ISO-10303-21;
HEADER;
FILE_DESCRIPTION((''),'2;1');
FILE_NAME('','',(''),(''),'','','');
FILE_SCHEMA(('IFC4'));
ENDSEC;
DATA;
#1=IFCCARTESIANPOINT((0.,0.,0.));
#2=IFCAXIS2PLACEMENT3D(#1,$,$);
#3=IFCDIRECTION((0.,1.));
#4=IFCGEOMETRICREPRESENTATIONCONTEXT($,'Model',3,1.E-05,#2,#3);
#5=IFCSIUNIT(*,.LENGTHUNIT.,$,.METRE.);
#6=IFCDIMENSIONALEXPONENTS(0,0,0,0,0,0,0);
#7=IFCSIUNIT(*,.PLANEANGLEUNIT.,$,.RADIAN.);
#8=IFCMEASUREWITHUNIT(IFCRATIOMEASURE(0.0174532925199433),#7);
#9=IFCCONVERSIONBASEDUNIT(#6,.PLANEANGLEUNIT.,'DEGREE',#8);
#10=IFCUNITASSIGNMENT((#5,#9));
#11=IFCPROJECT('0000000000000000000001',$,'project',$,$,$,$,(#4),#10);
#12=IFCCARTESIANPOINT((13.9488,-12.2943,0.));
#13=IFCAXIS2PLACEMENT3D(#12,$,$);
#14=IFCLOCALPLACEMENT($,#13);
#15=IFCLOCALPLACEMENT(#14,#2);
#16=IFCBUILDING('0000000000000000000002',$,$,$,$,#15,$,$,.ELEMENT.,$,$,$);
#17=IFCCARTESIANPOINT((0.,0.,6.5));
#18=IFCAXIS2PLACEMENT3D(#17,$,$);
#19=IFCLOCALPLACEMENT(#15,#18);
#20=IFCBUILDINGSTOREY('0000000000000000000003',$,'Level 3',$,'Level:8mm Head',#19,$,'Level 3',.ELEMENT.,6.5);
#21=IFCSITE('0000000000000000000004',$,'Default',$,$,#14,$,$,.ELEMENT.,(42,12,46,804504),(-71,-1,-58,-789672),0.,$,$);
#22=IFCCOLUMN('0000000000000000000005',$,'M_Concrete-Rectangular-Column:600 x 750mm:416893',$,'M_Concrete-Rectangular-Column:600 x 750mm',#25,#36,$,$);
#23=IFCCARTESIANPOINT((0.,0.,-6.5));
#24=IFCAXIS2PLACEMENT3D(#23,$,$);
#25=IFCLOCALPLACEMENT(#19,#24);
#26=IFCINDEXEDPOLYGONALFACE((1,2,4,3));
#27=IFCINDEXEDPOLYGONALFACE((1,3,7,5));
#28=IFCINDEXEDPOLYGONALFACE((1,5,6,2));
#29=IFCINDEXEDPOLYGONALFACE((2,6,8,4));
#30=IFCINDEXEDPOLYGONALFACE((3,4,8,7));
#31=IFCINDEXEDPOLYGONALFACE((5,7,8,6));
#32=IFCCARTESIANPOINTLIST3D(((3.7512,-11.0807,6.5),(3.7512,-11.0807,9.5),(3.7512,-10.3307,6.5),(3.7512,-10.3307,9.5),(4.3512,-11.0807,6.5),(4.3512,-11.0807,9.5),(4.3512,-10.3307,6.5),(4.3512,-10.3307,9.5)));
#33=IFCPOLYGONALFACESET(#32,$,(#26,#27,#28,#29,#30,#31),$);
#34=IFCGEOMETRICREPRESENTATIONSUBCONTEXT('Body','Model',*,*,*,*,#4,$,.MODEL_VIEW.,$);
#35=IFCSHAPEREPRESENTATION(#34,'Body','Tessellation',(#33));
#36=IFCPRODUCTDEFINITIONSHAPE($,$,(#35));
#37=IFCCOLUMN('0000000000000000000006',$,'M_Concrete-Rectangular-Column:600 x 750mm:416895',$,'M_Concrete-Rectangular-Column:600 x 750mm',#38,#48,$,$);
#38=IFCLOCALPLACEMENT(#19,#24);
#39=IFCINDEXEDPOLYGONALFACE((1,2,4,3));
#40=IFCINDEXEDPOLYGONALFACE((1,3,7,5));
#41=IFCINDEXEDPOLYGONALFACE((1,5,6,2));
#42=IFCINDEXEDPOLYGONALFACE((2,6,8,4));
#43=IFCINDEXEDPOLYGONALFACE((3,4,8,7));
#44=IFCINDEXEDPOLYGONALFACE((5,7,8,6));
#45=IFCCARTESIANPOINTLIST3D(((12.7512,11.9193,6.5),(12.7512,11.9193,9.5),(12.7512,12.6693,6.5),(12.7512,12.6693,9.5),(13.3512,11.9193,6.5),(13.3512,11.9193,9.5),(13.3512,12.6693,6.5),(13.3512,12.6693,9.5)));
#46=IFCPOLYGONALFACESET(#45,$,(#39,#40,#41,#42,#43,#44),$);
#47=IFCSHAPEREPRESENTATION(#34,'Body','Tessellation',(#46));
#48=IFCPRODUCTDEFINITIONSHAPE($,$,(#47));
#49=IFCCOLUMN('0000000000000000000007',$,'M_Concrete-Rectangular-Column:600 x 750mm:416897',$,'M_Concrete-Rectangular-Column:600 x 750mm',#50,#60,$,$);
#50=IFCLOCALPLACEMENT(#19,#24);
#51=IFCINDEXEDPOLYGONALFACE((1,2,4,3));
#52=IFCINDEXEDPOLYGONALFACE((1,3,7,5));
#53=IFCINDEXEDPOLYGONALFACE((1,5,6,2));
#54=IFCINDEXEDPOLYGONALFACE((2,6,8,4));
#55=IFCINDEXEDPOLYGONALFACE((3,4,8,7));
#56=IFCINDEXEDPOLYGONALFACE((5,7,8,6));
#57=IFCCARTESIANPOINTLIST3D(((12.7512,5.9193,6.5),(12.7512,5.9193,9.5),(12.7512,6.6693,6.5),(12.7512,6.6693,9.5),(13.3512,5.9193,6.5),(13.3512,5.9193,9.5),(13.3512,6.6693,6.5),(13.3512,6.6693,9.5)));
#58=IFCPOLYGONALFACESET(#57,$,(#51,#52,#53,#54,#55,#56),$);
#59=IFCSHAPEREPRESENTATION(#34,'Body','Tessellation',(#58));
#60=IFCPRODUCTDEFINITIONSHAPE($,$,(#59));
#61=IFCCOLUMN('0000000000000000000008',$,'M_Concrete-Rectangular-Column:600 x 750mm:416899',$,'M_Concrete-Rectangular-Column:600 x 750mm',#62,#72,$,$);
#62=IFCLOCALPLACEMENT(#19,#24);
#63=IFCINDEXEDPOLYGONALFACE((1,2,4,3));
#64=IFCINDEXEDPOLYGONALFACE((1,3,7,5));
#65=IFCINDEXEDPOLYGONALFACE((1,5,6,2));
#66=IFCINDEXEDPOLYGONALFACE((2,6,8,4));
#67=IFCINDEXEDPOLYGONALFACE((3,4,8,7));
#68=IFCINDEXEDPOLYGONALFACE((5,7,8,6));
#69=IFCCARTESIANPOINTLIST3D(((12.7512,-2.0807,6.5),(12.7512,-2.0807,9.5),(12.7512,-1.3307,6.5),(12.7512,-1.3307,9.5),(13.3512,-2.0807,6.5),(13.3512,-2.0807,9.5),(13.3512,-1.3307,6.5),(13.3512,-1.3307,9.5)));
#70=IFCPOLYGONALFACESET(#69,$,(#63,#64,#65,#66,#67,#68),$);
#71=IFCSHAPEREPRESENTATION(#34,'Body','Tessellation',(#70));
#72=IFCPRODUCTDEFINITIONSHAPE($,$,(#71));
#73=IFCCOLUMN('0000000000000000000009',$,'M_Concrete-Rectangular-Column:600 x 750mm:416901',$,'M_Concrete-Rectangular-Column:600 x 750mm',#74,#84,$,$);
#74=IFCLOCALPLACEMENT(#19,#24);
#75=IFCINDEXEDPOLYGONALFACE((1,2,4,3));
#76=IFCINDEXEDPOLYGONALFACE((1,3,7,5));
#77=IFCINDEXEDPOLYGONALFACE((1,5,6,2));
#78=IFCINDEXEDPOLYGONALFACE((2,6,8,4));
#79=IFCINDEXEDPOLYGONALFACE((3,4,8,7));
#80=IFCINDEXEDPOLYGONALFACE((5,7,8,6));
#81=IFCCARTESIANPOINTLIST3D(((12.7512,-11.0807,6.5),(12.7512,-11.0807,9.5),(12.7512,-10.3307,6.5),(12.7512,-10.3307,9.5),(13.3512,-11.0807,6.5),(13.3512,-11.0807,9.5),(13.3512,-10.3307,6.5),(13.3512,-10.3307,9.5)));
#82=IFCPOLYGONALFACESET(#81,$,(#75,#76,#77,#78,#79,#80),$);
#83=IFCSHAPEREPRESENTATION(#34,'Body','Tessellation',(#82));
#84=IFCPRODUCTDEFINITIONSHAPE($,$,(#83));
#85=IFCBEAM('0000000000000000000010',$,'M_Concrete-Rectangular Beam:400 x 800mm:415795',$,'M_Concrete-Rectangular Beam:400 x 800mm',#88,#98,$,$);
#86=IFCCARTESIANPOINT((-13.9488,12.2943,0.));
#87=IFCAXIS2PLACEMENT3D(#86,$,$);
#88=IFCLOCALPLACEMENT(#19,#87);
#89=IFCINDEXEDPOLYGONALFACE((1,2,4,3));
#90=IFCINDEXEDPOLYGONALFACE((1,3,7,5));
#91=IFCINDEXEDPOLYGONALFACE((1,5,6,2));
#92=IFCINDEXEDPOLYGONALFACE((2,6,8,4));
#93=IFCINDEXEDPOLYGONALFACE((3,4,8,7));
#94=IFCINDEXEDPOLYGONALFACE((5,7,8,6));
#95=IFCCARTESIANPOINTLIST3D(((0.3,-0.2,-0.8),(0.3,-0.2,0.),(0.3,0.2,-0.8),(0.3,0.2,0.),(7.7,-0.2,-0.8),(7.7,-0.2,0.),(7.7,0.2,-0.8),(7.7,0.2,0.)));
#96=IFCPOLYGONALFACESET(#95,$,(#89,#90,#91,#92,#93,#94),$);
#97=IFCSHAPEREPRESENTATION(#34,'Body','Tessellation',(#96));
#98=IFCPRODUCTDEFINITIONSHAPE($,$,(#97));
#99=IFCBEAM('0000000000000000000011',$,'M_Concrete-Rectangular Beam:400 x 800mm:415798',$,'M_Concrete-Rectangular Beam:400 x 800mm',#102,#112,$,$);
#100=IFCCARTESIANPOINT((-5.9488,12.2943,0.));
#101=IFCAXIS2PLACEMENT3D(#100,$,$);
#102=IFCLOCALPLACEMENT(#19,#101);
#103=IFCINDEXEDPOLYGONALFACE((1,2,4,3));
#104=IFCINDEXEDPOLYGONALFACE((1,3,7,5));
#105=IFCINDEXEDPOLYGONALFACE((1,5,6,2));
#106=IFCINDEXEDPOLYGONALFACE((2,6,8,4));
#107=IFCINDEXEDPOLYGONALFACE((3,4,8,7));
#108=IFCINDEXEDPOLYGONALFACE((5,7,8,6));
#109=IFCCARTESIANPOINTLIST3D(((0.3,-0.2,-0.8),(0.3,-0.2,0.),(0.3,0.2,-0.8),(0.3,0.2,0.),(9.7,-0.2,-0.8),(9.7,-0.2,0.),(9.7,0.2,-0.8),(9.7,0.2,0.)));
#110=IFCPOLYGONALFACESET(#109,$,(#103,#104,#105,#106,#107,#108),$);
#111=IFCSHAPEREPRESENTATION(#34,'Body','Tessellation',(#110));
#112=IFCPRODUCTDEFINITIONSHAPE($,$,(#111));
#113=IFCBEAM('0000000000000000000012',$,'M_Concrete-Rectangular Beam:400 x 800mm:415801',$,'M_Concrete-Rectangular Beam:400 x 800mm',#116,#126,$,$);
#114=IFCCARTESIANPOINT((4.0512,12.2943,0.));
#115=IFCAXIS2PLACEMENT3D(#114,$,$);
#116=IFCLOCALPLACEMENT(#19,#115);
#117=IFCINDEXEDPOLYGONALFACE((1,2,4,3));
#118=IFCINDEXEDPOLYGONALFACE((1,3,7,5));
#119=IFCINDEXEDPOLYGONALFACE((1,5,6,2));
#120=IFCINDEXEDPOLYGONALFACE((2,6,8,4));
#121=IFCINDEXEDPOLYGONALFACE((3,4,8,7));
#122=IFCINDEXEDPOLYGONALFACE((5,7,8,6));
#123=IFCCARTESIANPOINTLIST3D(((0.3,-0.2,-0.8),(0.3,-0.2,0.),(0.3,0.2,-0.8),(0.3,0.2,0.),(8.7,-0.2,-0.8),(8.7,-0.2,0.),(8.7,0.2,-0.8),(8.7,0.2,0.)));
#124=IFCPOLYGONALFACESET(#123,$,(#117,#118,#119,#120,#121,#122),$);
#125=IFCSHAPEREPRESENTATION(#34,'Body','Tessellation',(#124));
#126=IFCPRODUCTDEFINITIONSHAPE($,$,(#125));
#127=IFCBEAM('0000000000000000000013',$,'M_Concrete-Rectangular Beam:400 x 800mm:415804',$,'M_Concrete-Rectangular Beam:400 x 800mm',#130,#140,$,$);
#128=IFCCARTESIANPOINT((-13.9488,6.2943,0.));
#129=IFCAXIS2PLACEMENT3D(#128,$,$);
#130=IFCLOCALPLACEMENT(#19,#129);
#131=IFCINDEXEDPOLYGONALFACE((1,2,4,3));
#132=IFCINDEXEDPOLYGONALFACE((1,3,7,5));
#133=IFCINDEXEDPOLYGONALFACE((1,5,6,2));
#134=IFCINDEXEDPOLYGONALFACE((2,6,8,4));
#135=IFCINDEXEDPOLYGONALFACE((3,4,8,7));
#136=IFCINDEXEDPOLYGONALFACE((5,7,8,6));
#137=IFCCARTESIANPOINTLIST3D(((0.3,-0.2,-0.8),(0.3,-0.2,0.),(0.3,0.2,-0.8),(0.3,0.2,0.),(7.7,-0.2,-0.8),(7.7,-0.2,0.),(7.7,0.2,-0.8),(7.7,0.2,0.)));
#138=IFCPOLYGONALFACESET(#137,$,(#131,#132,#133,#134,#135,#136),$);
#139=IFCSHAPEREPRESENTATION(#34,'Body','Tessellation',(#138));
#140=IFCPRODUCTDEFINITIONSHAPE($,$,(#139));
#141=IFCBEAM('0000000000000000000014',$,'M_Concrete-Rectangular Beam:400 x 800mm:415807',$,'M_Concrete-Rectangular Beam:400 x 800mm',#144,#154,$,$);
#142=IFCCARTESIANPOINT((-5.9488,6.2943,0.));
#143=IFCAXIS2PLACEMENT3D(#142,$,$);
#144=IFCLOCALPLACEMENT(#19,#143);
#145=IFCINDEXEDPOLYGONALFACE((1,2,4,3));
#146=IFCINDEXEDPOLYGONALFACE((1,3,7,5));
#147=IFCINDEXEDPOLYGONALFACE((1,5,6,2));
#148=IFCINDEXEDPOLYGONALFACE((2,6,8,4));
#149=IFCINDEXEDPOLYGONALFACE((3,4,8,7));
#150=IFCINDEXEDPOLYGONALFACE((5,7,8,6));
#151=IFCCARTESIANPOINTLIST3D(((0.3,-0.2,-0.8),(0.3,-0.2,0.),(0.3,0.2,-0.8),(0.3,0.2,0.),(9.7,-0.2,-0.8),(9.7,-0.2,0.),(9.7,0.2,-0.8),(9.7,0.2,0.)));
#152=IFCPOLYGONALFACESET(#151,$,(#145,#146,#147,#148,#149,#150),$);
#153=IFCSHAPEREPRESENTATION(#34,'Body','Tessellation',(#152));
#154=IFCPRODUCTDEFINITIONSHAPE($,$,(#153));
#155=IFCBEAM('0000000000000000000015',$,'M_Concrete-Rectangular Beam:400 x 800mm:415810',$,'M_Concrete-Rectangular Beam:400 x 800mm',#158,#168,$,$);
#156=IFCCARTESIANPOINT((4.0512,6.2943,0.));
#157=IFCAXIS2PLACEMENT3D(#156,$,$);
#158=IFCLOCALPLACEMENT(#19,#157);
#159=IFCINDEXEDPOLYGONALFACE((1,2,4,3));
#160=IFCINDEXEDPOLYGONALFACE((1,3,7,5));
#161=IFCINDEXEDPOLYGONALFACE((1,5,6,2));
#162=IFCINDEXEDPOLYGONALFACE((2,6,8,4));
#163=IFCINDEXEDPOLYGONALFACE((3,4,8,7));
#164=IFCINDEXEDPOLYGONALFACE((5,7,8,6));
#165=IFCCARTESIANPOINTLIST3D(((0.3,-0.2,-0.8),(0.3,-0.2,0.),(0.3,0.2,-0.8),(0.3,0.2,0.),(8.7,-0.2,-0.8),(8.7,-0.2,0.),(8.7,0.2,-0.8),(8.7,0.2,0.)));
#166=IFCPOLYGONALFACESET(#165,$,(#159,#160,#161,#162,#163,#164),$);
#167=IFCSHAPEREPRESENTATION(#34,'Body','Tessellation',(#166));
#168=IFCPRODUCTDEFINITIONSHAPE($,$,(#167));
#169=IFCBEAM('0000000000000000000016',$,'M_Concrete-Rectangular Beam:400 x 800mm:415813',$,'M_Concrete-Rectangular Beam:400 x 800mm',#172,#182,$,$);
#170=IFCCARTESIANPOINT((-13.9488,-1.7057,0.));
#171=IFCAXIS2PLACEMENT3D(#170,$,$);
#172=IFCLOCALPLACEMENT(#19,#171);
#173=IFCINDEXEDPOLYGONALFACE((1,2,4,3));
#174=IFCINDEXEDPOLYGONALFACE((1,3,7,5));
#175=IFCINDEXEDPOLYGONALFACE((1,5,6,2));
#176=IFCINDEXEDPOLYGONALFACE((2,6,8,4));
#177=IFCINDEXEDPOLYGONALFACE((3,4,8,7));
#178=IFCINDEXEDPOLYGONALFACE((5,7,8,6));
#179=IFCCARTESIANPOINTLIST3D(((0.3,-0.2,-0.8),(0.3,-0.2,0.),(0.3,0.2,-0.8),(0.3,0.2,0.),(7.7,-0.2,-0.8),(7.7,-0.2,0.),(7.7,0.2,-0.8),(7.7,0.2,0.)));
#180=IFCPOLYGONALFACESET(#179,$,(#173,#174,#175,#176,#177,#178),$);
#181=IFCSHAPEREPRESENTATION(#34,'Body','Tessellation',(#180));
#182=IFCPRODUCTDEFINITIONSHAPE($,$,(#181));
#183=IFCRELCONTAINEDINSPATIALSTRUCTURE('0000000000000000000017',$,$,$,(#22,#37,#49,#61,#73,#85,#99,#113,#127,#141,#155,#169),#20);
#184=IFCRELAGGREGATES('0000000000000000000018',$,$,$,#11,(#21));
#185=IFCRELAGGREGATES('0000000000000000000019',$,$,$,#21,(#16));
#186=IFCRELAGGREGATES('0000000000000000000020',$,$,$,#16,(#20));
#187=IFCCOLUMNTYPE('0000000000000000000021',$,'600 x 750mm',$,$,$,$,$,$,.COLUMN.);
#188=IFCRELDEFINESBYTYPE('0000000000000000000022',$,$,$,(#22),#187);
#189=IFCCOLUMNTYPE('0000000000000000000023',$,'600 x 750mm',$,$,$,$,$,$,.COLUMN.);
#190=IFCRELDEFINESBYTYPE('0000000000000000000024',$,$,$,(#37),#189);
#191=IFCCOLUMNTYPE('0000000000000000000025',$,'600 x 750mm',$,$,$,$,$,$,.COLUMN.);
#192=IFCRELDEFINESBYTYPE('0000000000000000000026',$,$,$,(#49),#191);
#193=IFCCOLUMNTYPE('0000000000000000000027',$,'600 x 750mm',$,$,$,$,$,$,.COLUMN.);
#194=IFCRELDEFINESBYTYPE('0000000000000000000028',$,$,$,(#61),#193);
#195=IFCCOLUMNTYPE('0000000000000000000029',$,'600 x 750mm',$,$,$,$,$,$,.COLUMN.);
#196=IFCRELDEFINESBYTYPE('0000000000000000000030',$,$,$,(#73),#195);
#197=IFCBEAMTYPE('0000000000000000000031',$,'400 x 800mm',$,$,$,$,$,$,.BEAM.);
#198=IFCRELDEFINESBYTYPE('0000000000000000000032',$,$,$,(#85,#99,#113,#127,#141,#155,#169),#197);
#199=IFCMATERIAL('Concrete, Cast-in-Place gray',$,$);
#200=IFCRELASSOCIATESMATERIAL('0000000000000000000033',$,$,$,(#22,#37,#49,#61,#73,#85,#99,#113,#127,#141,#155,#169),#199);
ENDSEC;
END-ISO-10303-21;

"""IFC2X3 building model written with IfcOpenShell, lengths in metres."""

from ifc_helpers import new_model, entity, si_unit, converted_unit, direction, frame, frame_2d, origin, origin_2d_with_axis, place, context, subcontext, project, spatial, rectangle, extrude, source, transform, mapped, material, type_object, type_shapes, element, save


model = new_model("IFC2X3")

# Units and contexts
model_context = context("Model", 3, precision=1e-05, world=origin(), true_north=direction((0.0, 1.0)))
body_context = subcontext(model_context, "Body", "Model", "MODEL_VIEW")
ifc_project = project(units=[si_unit("LENGTHUNIT", "METRE"), converted_unit("PLANEANGLEUNIT", "DEGREE", entity("IfcRatioMeasure", 0.0174532925199433), si_unit("PLANEANGLEUNIT", "RADIAN"), dimensions=[0, 0, 0, 0, 0, 0, 0])], contexts=[model_context])

# Site, building, storey
site_placement = place(None, frame((13.9488, -12.2943, 0.0)))
site = spatial("IfcSite", under=ifc_project, at=site_placement, Name="Default", CompositionType="ELEMENT", RefLatitude=(42, 12, 46, 804504), RefLongitude=(-71, -1, -58, -789672), RefElevation=0.0)
building_placement = place(site_placement, origin())
building = spatial("IfcBuilding", under=site, at=building_placement, CompositionType="ELEMENT")
storey_placement = place(building_placement, frame((0.0, 0.0, 6.5)))
storey = spatial("IfcBuildingStorey", under=building, at=storey_placement, Name="Level 3", ObjectType="Level:8mm Head", LongName="Level 3", CompositionType="ELEMENT", Elevation=6.5)

# Columns
ifc_material = material(Name="Concrete, Cast-in-Place gray")
column_type_1 = type_object("IfcColumnType", Name="600 x 750mm", PredefinedType="COLUMN")
shared_shape_1 = source(origin(), body_context, "Body", "SweptSolid", [
    extrude(rectangle(XDim=0.75, YDim=0.6, at=origin_2d_with_axis()), frame((4.0512, -10.7057, 6.5), z_axis=(0.0, 0.0, 1.0), x_axis=(0.0, -1.0, 0.0)), (0.0, 0.0, 1.0), 3.0),
])
type_shapes(column_type_1, [shared_shape_1])
column_1_placement = place(storey_placement, frame((0.0, 0.0, -6.5)))
element("IfcColumn", 1, at=column_1_placement, inside=storey, type_object=column_type_1, material=ifc_material, Name="M_Concrete-Rectangular-Column:600 x 750mm:416893", ObjectType="M_Concrete-Rectangular-Column:600 x 750mm", context=body_context, shape_type="MappedRepresentation", body=[
    mapped(shared_shape_1, transform((0.0, 0.0, 0.0), scale=1.0)),
])
column_type_2 = type_object("IfcColumnType", Name="600 x 750mm", PredefinedType="COLUMN")
shared_shape_2 = source(origin(), body_context, "Body", "SweptSolid", [
    extrude(rectangle(XDim=0.75, YDim=0.6, at=frame_2d((0.0, 0.0), x_axis=(1.0, 0.0))), frame((13.0512, 12.2943, 6.5), z_axis=(0.0, 0.0, 1.0), x_axis=(0.0, -1.0, 0.0)), (0.0, 0.0, 1.0), 3.0),
])
type_shapes(column_type_2, [shared_shape_2])
column_2_placement = place(storey_placement, frame((0.0, 0.0, -6.5)))
element("IfcColumn", 2, at=column_2_placement, inside=storey, type_object=column_type_2, material=ifc_material, Name="M_Concrete-Rectangular-Column:600 x 750mm:416895", ObjectType="M_Concrete-Rectangular-Column:600 x 750mm", context=body_context, shape_type="MappedRepresentation", body=[
    mapped(shared_shape_2, transform((0.0, 0.0, 0.0), scale=1.0)),
])
column_type_3 = type_object("IfcColumnType", Name="600 x 750mm", PredefinedType="COLUMN")
shared_shape_3 = source(origin(), body_context, "Body", "SweptSolid", [
    extrude(rectangle(XDim=0.75, YDim=0.6, at=frame_2d((0.0, 0.0), x_axis=(1.0, 0.0))), frame((13.0512, 6.2943, 6.5), z_axis=(0.0, 0.0, 1.0), x_axis=(0.0, -1.0, 0.0)), (0.0, 0.0, 1.0), 3.0),
])
type_shapes(column_type_3, [shared_shape_3])
column_3_placement = place(storey_placement, frame((0.0, 0.0, -6.5)))
element("IfcColumn", 3, at=column_3_placement, inside=storey, type_object=column_type_3, material=ifc_material, Name="M_Concrete-Rectangular-Column:600 x 750mm:416897", ObjectType="M_Concrete-Rectangular-Column:600 x 750mm", context=body_context, shape_type="MappedRepresentation", body=[
    mapped(shared_shape_3, transform((0.0, 0.0, 0.0), scale=1.0)),
])
column_type_4 = type_object("IfcColumnType", Name="600 x 750mm", PredefinedType="COLUMN")
shared_shape_4 = source(origin(), body_context, "Body", "SweptSolid", [
    extrude(rectangle(XDim=0.75, YDim=0.6, at=frame_2d((0.0, 0.0), x_axis=(1.0, 0.0))), frame((13.0512, -1.7057, 6.5), z_axis=(0.0, 0.0, 1.0), x_axis=(0.0, -1.0, 0.0)), (0.0, 0.0, 1.0), 3.0),
])
type_shapes(column_type_4, [shared_shape_4])
column_4_placement = place(storey_placement, frame((0.0, 0.0, -6.5)))
element("IfcColumn", 4, at=column_4_placement, inside=storey, type_object=column_type_4, material=ifc_material, Name="M_Concrete-Rectangular-Column:600 x 750mm:416899", ObjectType="M_Concrete-Rectangular-Column:600 x 750mm", context=body_context, shape_type="MappedRepresentation", body=[
    mapped(shared_shape_4, transform((0.0, 0.0, 0.0), scale=1.0)),
])
column_type_5 = type_object("IfcColumnType", Name="600 x 750mm", PredefinedType="COLUMN")
shared_shape_5 = source(origin(), body_context, "Body", "SweptSolid", [
    extrude(rectangle(XDim=0.75, YDim=0.6, at=frame_2d((0.0, 0.0), x_axis=(1.0, 0.0))), frame((13.0512, -10.7057, 6.5), z_axis=(0.0, 0.0, 1.0), x_axis=(0.0, -1.0, 0.0)), (0.0, 0.0, 1.0), 3.0),
])
type_shapes(column_type_5, [shared_shape_5])
column_5_placement = place(storey_placement, frame((0.0, 0.0, -6.5)))
element("IfcColumn", 5, at=column_5_placement, inside=storey, type_object=column_type_5, material=ifc_material, Name="M_Concrete-Rectangular-Column:600 x 750mm:416901", ObjectType="M_Concrete-Rectangular-Column:600 x 750mm", context=body_context, shape_type="MappedRepresentation", body=[
    mapped(shared_shape_5, transform((0.0, 0.0, 0.0), scale=1.0)),
])

# Beams
beam_type_1 = type_object("IfcBeamType", Name="400 x 800mm", PredefinedType="BEAM")
beam_1_placement = place(storey_placement, frame((-13.9488, 12.2943, 0.0)))
element("IfcBeam", 6, at=beam_1_placement, inside=storey, type_object=beam_type_1, material=ifc_material, Name="M_Concrete-Rectangular Beam:400 x 800mm:415795", ObjectType="M_Concrete-Rectangular Beam:400 x 800mm", context=body_context, shape_type="SweptSolid", body=[
    extrude(rectangle(XDim=0.8, YDim=0.4, at=frame_2d((0.0, 0.0), x_axis=(1.0, 0.0))), frame((0.3, 0.0, -0.4), z_axis=(1.0, 0.0, 0.0), x_axis=(0.0, 0.0, -1.0)), (0.0, 0.0, 1.0), 7.4),
])
beam_2_placement = place(storey_placement, frame((-5.9488, 12.2943, 0.0)))
element("IfcBeam", 7, at=beam_2_placement, inside=storey, type_object=beam_type_1, material=ifc_material, Name="M_Concrete-Rectangular Beam:400 x 800mm:415798", ObjectType="M_Concrete-Rectangular Beam:400 x 800mm", context=body_context, shape_type="SweptSolid", body=[
    extrude(rectangle(XDim=0.8, YDim=0.4, at=frame_2d((0.0, 0.0), x_axis=(1.0, 0.0))), frame((0.3, 0.0, -0.4), z_axis=(1.0, 0.0, 0.0), x_axis=(0.0, 0.0, -1.0)), (0.0, 0.0, 1.0), 9.4),
])
beam_3_placement = place(storey_placement, frame((4.0512, 12.2943, 0.0)))
element("IfcBeam", 8, at=beam_3_placement, inside=storey, type_object=beam_type_1, material=ifc_material, Name="M_Concrete-Rectangular Beam:400 x 800mm:415801", ObjectType="M_Concrete-Rectangular Beam:400 x 800mm", context=body_context, shape_type="SweptSolid", body=[
    extrude(rectangle(XDim=0.8, YDim=0.4, at=frame_2d((0.0, 0.0), x_axis=(1.0, 0.0))), frame((0.3, 0.0, -0.4), z_axis=(1.0, 0.0, 0.0), x_axis=(0.0, 0.0, -1.0)), (0.0, 0.0, 1.0), 8.4),
])
beam_4_placement = place(storey_placement, frame((-13.9488, 6.2943, 0.0)))
element("IfcBeam", 9, at=beam_4_placement, inside=storey, type_object=beam_type_1, material=ifc_material, Name="M_Concrete-Rectangular Beam:400 x 800mm:415804", ObjectType="M_Concrete-Rectangular Beam:400 x 800mm", context=body_context, shape_type="SweptSolid", body=[
    extrude(rectangle(XDim=0.8, YDim=0.4, at=frame_2d((0.0, 0.0), x_axis=(1.0, 0.0))), frame((0.3, 0.0, -0.4), z_axis=(1.0, 0.0, 0.0), x_axis=(0.0, 0.0, -1.0)), (0.0, 0.0, 1.0), 7.4),
])
beam_5_placement = place(storey_placement, frame((-5.9488, 6.2943, 0.0)))
element("IfcBeam", 10, at=beam_5_placement, inside=storey, type_object=beam_type_1, material=ifc_material, Name="M_Concrete-Rectangular Beam:400 x 800mm:415807", ObjectType="M_Concrete-Rectangular Beam:400 x 800mm", context=body_context, shape_type="SweptSolid", body=[
    extrude(rectangle(XDim=0.8, YDim=0.4, at=frame_2d((0.0, 0.0), x_axis=(1.0, 0.0))), frame((0.3, 0.0, -0.4), z_axis=(1.0, 0.0, 0.0), x_axis=(0.0, 0.0, -1.0)), (0.0, 0.0, 1.0), 9.4),
])
beam_6_placement = place(storey_placement, frame((4.0512, 6.2943, 0.0)))
element("IfcBeam", 11, at=beam_6_placement, inside=storey, type_object=beam_type_1, material=ifc_material, Name="M_Concrete-Rectangular Beam:400 x 800mm:415810", ObjectType="M_Concrete-Rectangular Beam:400 x 800mm", context=body_context, shape_type="SweptSolid", body=[
    extrude(rectangle(XDim=0.8, YDim=0.4, at=frame_2d((0.0, 0.0), x_axis=(1.0, 0.0))), frame((0.3, 0.0, -0.4), z_axis=(1.0, 0.0, 0.0), x_axis=(0.0, 0.0, -1.0)), (0.0, 0.0, 1.0), 8.4),
])
beam_7_placement = place(storey_placement, frame((-13.9488, -1.7057, 0.0)))
element("IfcBeam", 12, at=beam_7_placement, inside=storey, type_object=beam_type_1, material=ifc_material, Name="M_Concrete-Rectangular Beam:400 x 800mm:415813", ObjectType="M_Concrete-Rectangular Beam:400 x 800mm", context=body_context, shape_type="SweptSolid", body=[
    extrude(rectangle(XDim=0.8, YDim=0.4, at=frame_2d((0.0, 0.0), x_axis=(1.0, 0.0))), frame((0.3, 0.0, -0.4), z_axis=(1.0, 0.0, 0.0), x_axis=(0.0, 0.0, -1.0)), (0.0, 0.0, 1.0), 7.4),
])

save(model, "model.ifc")
